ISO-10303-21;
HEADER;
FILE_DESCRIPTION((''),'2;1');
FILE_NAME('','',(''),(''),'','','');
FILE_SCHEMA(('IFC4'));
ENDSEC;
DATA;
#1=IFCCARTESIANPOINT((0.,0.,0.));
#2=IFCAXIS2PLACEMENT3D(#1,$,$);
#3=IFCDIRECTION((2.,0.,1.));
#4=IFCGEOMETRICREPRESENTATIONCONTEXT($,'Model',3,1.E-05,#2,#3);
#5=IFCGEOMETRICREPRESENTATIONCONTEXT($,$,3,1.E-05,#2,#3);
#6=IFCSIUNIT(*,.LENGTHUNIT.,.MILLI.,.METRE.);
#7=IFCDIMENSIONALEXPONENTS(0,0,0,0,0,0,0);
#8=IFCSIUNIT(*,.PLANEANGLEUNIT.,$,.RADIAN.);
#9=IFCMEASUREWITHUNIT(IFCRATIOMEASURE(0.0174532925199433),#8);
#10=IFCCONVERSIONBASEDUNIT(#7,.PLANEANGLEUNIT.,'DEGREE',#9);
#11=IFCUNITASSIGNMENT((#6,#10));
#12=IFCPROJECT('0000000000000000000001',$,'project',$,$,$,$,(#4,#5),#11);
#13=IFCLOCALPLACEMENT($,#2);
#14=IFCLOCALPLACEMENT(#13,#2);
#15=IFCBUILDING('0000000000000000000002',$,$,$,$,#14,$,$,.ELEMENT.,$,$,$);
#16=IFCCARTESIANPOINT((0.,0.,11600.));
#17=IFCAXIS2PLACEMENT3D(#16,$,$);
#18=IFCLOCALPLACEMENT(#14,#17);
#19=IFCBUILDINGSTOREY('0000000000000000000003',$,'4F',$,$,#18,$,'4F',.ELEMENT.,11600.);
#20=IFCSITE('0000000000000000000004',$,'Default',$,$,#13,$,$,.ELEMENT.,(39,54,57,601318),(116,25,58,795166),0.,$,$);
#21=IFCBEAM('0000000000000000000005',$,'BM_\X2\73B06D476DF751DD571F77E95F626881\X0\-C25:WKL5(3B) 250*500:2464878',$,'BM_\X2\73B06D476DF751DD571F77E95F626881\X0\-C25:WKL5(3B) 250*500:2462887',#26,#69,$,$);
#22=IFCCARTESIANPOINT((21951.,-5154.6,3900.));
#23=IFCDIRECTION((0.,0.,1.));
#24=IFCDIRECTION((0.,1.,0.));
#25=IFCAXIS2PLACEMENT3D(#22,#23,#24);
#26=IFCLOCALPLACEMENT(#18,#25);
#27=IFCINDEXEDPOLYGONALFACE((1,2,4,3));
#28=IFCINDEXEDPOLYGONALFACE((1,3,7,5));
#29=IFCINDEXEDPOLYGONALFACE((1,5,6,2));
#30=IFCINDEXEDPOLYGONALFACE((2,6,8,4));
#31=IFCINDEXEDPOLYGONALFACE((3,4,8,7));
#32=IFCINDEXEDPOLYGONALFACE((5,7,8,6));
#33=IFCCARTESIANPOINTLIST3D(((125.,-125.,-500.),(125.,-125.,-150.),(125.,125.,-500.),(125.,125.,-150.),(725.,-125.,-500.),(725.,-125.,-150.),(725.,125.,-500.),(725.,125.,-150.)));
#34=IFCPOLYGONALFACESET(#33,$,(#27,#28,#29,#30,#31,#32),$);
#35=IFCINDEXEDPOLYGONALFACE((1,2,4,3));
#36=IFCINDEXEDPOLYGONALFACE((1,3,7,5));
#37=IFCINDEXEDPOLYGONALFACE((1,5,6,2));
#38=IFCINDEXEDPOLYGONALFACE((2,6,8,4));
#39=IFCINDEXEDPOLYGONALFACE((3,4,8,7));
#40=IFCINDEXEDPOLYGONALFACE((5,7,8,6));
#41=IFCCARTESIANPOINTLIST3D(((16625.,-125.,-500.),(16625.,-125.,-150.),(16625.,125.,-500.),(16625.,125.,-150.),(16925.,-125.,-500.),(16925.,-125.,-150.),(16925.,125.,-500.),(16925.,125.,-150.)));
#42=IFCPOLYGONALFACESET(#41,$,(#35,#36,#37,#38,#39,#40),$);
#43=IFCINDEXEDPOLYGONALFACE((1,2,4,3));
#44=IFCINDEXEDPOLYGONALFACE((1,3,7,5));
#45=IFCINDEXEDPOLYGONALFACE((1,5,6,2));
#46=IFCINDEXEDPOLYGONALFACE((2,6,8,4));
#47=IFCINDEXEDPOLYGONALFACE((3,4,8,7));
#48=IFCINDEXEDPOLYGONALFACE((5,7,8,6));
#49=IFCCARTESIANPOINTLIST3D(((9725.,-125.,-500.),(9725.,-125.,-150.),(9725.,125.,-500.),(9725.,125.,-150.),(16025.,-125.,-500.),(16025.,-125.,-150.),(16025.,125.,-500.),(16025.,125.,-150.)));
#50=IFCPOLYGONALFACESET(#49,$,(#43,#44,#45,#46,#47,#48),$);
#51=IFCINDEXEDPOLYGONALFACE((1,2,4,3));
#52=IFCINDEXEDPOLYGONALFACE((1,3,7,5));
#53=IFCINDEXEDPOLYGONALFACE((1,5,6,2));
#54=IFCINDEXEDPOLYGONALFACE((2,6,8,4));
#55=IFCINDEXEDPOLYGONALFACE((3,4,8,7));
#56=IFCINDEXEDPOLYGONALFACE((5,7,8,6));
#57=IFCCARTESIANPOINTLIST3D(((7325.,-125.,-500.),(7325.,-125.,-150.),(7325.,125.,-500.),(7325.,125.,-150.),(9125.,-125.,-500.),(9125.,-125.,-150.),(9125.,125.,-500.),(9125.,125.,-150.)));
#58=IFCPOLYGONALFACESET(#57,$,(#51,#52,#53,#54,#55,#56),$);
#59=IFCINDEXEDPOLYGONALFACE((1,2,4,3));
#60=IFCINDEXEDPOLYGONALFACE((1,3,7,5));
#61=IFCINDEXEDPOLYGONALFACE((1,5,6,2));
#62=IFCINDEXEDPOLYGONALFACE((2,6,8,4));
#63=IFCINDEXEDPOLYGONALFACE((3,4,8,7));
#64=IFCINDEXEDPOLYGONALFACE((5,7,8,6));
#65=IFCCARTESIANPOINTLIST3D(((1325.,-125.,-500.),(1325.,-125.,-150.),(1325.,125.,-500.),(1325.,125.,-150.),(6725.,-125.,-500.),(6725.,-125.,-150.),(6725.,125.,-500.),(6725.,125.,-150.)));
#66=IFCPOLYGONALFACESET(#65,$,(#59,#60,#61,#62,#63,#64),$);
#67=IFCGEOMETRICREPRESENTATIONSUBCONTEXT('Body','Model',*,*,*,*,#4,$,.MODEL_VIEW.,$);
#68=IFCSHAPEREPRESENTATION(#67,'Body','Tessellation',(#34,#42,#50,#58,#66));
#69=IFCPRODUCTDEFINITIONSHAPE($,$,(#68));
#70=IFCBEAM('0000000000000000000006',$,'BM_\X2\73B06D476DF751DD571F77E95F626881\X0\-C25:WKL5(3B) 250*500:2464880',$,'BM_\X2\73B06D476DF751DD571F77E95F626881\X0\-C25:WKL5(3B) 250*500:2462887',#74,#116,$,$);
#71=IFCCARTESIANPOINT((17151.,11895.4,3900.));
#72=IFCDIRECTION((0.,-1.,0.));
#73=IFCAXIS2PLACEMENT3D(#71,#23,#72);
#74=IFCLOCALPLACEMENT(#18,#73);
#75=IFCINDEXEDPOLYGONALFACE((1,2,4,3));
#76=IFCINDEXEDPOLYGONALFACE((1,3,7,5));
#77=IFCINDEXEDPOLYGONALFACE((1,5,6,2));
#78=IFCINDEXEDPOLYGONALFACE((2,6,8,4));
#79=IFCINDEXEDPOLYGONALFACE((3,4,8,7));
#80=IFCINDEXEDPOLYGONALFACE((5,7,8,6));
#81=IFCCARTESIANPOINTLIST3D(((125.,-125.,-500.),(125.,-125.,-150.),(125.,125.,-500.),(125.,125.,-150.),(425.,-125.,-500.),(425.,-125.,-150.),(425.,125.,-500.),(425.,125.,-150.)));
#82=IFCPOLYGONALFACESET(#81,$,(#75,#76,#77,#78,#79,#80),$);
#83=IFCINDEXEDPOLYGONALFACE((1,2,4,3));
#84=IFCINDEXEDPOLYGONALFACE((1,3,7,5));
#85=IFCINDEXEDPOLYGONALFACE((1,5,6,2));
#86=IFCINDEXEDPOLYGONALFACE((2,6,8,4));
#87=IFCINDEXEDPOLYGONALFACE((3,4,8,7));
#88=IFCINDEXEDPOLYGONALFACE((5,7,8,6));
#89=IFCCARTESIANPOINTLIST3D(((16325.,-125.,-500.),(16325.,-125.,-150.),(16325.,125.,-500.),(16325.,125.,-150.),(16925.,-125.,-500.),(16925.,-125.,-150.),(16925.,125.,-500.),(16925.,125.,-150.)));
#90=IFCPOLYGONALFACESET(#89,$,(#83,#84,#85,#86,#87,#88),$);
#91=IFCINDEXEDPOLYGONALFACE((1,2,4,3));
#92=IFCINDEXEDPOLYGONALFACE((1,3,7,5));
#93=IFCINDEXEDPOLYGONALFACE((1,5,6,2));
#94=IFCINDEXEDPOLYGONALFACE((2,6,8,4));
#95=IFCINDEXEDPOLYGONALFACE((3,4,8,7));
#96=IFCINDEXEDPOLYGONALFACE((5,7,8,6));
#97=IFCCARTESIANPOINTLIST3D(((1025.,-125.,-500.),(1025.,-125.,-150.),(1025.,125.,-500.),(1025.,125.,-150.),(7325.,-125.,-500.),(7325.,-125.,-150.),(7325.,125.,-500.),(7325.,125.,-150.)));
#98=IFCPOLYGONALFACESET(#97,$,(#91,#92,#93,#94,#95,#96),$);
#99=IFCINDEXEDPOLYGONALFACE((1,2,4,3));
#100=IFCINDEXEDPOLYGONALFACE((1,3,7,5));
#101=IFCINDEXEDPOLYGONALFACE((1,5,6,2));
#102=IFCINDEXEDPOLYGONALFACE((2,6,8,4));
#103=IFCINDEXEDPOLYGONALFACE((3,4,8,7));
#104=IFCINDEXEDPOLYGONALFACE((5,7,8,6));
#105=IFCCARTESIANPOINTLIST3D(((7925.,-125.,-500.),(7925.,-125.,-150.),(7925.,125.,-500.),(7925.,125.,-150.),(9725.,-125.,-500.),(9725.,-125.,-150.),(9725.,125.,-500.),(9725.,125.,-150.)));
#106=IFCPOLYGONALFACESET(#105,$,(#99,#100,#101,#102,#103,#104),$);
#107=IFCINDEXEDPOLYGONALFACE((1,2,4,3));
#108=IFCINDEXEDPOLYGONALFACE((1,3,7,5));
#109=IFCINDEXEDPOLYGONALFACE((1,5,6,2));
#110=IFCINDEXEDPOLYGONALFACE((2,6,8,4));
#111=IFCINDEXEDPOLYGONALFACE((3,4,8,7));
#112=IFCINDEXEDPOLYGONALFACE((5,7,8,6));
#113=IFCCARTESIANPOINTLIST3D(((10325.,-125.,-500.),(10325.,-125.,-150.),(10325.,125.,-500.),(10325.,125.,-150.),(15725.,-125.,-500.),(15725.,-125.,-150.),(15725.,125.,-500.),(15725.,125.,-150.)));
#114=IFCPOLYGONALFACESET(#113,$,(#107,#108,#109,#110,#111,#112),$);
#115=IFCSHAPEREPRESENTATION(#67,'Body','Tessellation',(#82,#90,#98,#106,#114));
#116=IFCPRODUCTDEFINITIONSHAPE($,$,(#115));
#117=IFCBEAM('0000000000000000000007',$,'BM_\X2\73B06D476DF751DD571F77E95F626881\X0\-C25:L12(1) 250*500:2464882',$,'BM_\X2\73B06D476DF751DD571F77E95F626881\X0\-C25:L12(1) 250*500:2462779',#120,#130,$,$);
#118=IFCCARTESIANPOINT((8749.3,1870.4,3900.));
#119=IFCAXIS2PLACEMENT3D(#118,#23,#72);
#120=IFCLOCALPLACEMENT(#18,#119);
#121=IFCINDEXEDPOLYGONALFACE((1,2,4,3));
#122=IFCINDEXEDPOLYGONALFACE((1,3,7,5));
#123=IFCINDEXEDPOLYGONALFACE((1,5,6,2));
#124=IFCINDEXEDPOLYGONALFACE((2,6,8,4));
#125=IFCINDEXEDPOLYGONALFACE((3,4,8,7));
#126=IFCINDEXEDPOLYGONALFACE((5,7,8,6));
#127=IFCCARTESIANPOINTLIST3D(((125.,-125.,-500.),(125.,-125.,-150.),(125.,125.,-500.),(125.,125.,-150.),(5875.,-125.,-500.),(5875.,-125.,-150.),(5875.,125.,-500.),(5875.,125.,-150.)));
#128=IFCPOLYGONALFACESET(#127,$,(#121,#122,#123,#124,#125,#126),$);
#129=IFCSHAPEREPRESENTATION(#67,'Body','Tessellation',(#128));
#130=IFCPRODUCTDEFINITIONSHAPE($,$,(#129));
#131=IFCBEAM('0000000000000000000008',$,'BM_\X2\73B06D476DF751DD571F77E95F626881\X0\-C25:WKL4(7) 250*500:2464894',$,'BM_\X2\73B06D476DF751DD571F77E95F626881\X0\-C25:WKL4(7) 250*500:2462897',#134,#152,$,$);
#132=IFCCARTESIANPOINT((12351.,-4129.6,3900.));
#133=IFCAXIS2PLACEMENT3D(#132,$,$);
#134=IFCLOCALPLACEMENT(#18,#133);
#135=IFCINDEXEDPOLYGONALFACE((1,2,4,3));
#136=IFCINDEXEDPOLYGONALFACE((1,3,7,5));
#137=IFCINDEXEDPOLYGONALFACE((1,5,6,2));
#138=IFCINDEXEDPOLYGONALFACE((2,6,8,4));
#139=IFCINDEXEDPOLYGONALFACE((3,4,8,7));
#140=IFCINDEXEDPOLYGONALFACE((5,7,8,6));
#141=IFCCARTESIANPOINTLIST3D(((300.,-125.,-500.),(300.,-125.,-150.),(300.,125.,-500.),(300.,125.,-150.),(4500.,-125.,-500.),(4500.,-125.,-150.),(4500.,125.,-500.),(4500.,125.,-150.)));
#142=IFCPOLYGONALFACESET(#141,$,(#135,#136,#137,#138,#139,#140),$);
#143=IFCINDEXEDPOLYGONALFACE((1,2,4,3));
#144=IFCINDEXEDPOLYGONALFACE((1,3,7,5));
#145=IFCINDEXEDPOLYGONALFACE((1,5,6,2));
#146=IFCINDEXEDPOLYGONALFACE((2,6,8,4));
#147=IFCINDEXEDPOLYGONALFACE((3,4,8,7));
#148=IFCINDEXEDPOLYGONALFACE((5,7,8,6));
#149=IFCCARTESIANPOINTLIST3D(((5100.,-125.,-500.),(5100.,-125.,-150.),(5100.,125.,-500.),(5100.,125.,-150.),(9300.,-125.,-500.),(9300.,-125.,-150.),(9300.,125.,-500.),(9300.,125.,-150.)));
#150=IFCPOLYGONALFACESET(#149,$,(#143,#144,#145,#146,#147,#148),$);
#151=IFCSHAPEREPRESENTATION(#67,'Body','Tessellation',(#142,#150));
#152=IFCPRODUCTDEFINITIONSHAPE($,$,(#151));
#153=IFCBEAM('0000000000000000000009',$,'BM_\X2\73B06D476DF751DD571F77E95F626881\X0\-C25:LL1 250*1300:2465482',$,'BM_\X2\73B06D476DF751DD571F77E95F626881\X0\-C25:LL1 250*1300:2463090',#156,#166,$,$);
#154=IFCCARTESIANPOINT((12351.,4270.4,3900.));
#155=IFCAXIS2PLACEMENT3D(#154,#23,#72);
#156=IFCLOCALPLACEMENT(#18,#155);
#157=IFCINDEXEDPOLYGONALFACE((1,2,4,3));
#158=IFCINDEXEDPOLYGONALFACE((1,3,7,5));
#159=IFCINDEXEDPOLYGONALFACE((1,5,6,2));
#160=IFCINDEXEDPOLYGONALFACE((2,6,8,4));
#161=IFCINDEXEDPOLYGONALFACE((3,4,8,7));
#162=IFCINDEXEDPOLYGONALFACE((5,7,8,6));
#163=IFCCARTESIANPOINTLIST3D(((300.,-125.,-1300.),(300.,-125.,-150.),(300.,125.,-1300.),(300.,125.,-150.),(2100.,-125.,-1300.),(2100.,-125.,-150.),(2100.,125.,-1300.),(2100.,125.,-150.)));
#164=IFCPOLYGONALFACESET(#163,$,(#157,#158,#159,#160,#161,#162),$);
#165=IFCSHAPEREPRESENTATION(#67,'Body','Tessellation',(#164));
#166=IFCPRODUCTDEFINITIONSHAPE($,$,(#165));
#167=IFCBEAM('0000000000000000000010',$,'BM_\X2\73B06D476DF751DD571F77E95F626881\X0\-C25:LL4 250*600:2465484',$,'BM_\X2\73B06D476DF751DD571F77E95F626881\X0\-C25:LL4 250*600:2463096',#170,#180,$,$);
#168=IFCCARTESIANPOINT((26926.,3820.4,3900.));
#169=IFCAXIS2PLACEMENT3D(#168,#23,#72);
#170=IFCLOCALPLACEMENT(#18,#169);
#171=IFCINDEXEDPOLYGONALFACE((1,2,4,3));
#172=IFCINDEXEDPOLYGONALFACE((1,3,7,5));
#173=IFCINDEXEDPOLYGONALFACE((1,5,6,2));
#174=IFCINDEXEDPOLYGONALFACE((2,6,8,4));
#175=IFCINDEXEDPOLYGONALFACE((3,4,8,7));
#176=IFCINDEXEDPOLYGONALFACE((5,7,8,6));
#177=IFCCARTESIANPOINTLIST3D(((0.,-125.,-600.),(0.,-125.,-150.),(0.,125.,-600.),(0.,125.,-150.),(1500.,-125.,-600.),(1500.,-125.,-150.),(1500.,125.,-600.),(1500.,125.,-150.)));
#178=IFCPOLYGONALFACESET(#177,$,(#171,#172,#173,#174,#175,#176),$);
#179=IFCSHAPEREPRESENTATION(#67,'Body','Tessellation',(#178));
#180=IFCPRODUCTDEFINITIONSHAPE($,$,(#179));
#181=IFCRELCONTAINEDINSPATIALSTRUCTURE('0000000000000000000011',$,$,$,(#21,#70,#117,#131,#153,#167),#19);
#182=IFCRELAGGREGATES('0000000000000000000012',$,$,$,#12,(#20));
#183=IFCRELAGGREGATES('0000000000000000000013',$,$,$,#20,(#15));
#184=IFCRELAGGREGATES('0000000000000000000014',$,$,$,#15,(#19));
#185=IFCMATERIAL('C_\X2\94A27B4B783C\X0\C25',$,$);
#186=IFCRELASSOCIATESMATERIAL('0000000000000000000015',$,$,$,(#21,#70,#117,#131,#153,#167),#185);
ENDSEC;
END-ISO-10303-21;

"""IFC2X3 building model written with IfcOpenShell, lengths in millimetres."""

from ifc_helpers import new_model, entity, si_unit, converted_unit, direction, frame, frame_2d, origin, origin_2d_with_axis, place, context, subcontext, project, spatial, rectangle, extrude, material, element, save


model = new_model("IFC2X3")

# Units and contexts
model_context = context("Model", 3, precision=1e-05, world=origin(), true_north=direction((2.0, 0.0, 1.0)))
context_of_model = context(None, 3, precision=1e-05, world=origin(), true_north=direction((2.0, 0.0, 1.0)))
body_context = subcontext(model_context, "Body", "Model", "MODEL_VIEW")
ifc_project = project(units=[si_unit("LENGTHUNIT", "METRE", prefix="MILLI"), converted_unit("PLANEANGLEUNIT", "DEGREE", entity("IfcRatioMeasure", 0.0174532925199433), si_unit("PLANEANGLEUNIT", "RADIAN"), dimensions=[0, 0, 0, 0, 0, 0, 0])], contexts=[model_context, context_of_model])

# Site, building, storey
site_placement = place(None, origin())
site = spatial("IfcSite", under=ifc_project, at=site_placement, Name="Default", CompositionType="ELEMENT", RefLatitude=(39, 54, 57, 601318), RefLongitude=(116, 25, 58, 795166), RefElevation=0.0)
building_placement = place(site_placement, origin())
building = spatial("IfcBuilding", under=site, at=building_placement, CompositionType="ELEMENT")
storey_placement = place(building_placement, frame((0.0, 0.0, 11600.0)))
storey = spatial("IfcBuildingStorey", under=building, at=storey_placement, Name="4F", LongName="4F", CompositionType="ELEMENT", Elevation=11600.0)

# Shared definitions
ifc_material = material(Name="C_钢筋砼C25")

# Beams
beam_1_placement = place(storey_placement, frame((21951.0, -5154.6, 3900.0), z_axis=(0.0, 0.0, 1.0), x_axis=(0.0, 1.0, 0.0)))
element("IfcBeam", 1, at=beam_1_placement, inside=storey, material=ifc_material, Name="BM_现浇混凝土矩形梁-C25:WKL5(3B) 250*500:2464878", ObjectType="BM_现浇混凝土矩形梁-C25:WKL5(3B) 250*500:2462887", context=body_context, shape_type="SweptSolid", body=[
    extrude(rectangle(XDim=350.0, YDim=250.0, at=frame_2d((0.0, 0.0), x_axis=(1.0, 0.0))), frame((125.0, 0.0, -325.0), z_axis=(1.0, 0.0, 0.0), x_axis=(0.0, 0.0, 1.0)), (0.0, 0.0, 1.0), 600.0),
    extrude(rectangle(XDim=350.0, YDim=250.0, at=frame_2d((0.0, 0.0), x_axis=(1.0, 0.0))), frame((16625.0, 0.0, -325.0), z_axis=(1.0, 0.0, 0.0), x_axis=(0.0, 0.0, 1.0)), (0.0, 0.0, 1.0), 300.0),
    extrude(rectangle(XDim=350.0, YDim=250.0, at=frame_2d((0.0, 0.0), x_axis=(1.0, 0.0))), frame((9725.0, 0.0, -325.0), z_axis=(1.0, 0.0, 0.0), x_axis=(0.0, 0.0, 1.0)), (0.0, 0.0, 1.0), 6300.0),
    extrude(rectangle(XDim=350.0, YDim=250.0, at=frame_2d((0.0, 0.0), x_axis=(1.0, 0.0))), frame((7325.0, 0.0, -325.0), z_axis=(1.0, 0.0, 0.0), x_axis=(0.0, 0.0, 1.0)), (0.0, 0.0, 1.0), 1800.0),
    extrude(rectangle(XDim=350.0, YDim=250.0, at=origin_2d_with_axis()), frame((1325.0, 0.0, -325.0), z_axis=(1.0, 0.0, 0.0), x_axis=(0.0, 0.0, 1.0)), (0.0, 0.0, 1.0), 5400.0),
])
beam_2_placement = place(storey_placement, frame((17151.0, 11895.4, 3900.0), z_axis=(0.0, 0.0, 1.0), x_axis=(0.0, -1.0, 0.0)))
element("IfcBeam", 2, at=beam_2_placement, inside=storey, material=ifc_material, Name="BM_现浇混凝土矩形梁-C25:WKL5(3B) 250*500:2464880", ObjectType="BM_现浇混凝土矩形梁-C25:WKL5(3B) 250*500:2462887", context=body_context, shape_type="SweptSolid", body=[
    extrude(rectangle(XDim=350.0, YDim=250.0, at=frame_2d((0.0, 0.0), x_axis=(1.0, 0.0))), frame((125.0, 0.0, -325.0), z_axis=(1.0, 0.0, 0.0), x_axis=(0.0, 0.0, 1.0)), (0.0, 0.0, 1.0), 300.0),
    extrude(rectangle(XDim=350.0, YDim=250.0, at=frame_2d((0.0, 0.0), x_axis=(1.0, 0.0))), frame((16325.0, 0.0, -325.0), z_axis=(1.0, 0.0, 0.0), x_axis=(0.0, 0.0, 1.0)), (0.0, 0.0, 1.0), 600.0),
    extrude(rectangle(XDim=350.0, YDim=250.0, at=origin_2d_with_axis()), frame((1025.0, 0.0, -325.0), z_axis=(1.0, 0.0, 0.0), x_axis=(0.0, 0.0, 1.0)), (0.0, 0.0, 1.0), 6300.0),
    extrude(rectangle(XDim=350.0, YDim=250.0, at=origin_2d_with_axis()), frame((7925.0, 0.0, -325.0), z_axis=(1.0, 0.0, 0.0), x_axis=(0.0, 0.0, 1.0)), (0.0, 0.0, 1.0), 1800.0),
    extrude(rectangle(XDim=350.0, YDim=250.0, at=frame_2d((0.0, 0.0), x_axis=(1.0, 0.0))), frame((10325.0, 0.0, -325.0), z_axis=(1.0, 0.0, 0.0), x_axis=(0.0, 0.0, 1.0)), (0.0, 0.0, 1.0), 5400.0),
])
beam_3_placement = place(storey_placement, frame((8749.3, 1870.4, 3900.0), z_axis=(0.0, 0.0, 1.0), x_axis=(0.0, -1.0, 0.0)))
element("IfcBeam", 3, at=beam_3_placement, inside=storey, material=ifc_material, Name="BM_现浇混凝土矩形梁-C25:L12(1) 250*500:2464882", ObjectType="BM_现浇混凝土矩形梁-C25:L12(1) 250*500:2462779", context=body_context, shape_type="SweptSolid", body=[
    extrude(rectangle(XDim=350.0, YDim=250.0, at=frame_2d((0.0, 0.0), x_axis=(1.0, 0.0))), frame((125.0, 0.0, -325.0), z_axis=(1.0, 0.0, 0.0), x_axis=(0.0, 0.0, -1.0)), (0.0, 0.0, 1.0), 5750.0),
])
beam_4_placement = place(storey_placement, frame((12351.0, -4129.6, 3900.0)))
element("IfcBeam", 4, at=beam_4_placement, inside=storey, material=ifc_material, Name="BM_现浇混凝土矩形梁-C25:WKL4(7) 250*500:2464894", ObjectType="BM_现浇混凝土矩形梁-C25:WKL4(7) 250*500:2462897", context=body_context, shape_type="SweptSolid", body=[
    extrude(rectangle(XDim=350.0, YDim=250.0, at=frame_2d((0.0, 0.0), x_axis=(1.0, 0.0))), frame((300.0, 0.0, -325.0), z_axis=(1.0, 0.0, 0.0), x_axis=(0.0, 0.0, 1.0)), (0.0, 0.0, 1.0), 4200.0),
    extrude(rectangle(XDim=350.0, YDim=250.0, at=frame_2d((0.0, 0.0), x_axis=(1.0, 0.0))), frame((5100.0, 0.0, -325.0), z_axis=(1.0, 0.0, 0.0), x_axis=(0.0, 0.0, 1.0)), (0.0, 0.0, 1.0), 4200.0),
])
beam_5_placement = place(storey_placement, frame((12351.0, 4270.4, 3900.0), z_axis=(0.0, 0.0, 1.0), x_axis=(0.0, -1.0, 0.0)))
element("IfcBeam", 5, at=beam_5_placement, inside=storey, material=ifc_material, Name="BM_现浇混凝土矩形梁-C25:LL1 250*1300:2465482", ObjectType="BM_现浇混凝土矩形梁-C25:LL1 250*1300:2463090", context=body_context, shape_type="SweptSolid", body=[
    extrude(rectangle(XDim=1150.0, YDim=250.0, at=frame_2d((0.0, 0.0), x_axis=(1.0, 0.0))), frame((300.0, 0.0, -725.0), z_axis=(1.0, 0.0, 0.0), x_axis=(0.0, 0.0, -1.0)), (0.0, 0.0, 1.0), 1800.0),
])
beam_6_placement = place(storey_placement, frame((26926.0, 3820.4, 3900.0), z_axis=(0.0, 0.0, 1.0), x_axis=(0.0, -1.0, 0.0)))
element("IfcBeam", 6, at=beam_6_placement, inside=storey, material=ifc_material, Name="BM_现浇混凝土矩形梁-C25:LL4 250*600:2465484", ObjectType="BM_现浇混凝土矩形梁-C25:LL4 250*600:2463096", context=body_context, shape_type="SweptSolid", body=[
    extrude(rectangle(XDim=450.0, YDim=250.0, at=frame_2d((0.0, 0.0), x_axis=(1.0, 0.0))), frame((0.0, 0.0, -375.0), z_axis=(1.0, 0.0, 0.0), x_axis=(0.0, 0.0, -1.0)), (0.0, 0.0, 1.0), 1500.0),
])

save(model, "model.ifc")
